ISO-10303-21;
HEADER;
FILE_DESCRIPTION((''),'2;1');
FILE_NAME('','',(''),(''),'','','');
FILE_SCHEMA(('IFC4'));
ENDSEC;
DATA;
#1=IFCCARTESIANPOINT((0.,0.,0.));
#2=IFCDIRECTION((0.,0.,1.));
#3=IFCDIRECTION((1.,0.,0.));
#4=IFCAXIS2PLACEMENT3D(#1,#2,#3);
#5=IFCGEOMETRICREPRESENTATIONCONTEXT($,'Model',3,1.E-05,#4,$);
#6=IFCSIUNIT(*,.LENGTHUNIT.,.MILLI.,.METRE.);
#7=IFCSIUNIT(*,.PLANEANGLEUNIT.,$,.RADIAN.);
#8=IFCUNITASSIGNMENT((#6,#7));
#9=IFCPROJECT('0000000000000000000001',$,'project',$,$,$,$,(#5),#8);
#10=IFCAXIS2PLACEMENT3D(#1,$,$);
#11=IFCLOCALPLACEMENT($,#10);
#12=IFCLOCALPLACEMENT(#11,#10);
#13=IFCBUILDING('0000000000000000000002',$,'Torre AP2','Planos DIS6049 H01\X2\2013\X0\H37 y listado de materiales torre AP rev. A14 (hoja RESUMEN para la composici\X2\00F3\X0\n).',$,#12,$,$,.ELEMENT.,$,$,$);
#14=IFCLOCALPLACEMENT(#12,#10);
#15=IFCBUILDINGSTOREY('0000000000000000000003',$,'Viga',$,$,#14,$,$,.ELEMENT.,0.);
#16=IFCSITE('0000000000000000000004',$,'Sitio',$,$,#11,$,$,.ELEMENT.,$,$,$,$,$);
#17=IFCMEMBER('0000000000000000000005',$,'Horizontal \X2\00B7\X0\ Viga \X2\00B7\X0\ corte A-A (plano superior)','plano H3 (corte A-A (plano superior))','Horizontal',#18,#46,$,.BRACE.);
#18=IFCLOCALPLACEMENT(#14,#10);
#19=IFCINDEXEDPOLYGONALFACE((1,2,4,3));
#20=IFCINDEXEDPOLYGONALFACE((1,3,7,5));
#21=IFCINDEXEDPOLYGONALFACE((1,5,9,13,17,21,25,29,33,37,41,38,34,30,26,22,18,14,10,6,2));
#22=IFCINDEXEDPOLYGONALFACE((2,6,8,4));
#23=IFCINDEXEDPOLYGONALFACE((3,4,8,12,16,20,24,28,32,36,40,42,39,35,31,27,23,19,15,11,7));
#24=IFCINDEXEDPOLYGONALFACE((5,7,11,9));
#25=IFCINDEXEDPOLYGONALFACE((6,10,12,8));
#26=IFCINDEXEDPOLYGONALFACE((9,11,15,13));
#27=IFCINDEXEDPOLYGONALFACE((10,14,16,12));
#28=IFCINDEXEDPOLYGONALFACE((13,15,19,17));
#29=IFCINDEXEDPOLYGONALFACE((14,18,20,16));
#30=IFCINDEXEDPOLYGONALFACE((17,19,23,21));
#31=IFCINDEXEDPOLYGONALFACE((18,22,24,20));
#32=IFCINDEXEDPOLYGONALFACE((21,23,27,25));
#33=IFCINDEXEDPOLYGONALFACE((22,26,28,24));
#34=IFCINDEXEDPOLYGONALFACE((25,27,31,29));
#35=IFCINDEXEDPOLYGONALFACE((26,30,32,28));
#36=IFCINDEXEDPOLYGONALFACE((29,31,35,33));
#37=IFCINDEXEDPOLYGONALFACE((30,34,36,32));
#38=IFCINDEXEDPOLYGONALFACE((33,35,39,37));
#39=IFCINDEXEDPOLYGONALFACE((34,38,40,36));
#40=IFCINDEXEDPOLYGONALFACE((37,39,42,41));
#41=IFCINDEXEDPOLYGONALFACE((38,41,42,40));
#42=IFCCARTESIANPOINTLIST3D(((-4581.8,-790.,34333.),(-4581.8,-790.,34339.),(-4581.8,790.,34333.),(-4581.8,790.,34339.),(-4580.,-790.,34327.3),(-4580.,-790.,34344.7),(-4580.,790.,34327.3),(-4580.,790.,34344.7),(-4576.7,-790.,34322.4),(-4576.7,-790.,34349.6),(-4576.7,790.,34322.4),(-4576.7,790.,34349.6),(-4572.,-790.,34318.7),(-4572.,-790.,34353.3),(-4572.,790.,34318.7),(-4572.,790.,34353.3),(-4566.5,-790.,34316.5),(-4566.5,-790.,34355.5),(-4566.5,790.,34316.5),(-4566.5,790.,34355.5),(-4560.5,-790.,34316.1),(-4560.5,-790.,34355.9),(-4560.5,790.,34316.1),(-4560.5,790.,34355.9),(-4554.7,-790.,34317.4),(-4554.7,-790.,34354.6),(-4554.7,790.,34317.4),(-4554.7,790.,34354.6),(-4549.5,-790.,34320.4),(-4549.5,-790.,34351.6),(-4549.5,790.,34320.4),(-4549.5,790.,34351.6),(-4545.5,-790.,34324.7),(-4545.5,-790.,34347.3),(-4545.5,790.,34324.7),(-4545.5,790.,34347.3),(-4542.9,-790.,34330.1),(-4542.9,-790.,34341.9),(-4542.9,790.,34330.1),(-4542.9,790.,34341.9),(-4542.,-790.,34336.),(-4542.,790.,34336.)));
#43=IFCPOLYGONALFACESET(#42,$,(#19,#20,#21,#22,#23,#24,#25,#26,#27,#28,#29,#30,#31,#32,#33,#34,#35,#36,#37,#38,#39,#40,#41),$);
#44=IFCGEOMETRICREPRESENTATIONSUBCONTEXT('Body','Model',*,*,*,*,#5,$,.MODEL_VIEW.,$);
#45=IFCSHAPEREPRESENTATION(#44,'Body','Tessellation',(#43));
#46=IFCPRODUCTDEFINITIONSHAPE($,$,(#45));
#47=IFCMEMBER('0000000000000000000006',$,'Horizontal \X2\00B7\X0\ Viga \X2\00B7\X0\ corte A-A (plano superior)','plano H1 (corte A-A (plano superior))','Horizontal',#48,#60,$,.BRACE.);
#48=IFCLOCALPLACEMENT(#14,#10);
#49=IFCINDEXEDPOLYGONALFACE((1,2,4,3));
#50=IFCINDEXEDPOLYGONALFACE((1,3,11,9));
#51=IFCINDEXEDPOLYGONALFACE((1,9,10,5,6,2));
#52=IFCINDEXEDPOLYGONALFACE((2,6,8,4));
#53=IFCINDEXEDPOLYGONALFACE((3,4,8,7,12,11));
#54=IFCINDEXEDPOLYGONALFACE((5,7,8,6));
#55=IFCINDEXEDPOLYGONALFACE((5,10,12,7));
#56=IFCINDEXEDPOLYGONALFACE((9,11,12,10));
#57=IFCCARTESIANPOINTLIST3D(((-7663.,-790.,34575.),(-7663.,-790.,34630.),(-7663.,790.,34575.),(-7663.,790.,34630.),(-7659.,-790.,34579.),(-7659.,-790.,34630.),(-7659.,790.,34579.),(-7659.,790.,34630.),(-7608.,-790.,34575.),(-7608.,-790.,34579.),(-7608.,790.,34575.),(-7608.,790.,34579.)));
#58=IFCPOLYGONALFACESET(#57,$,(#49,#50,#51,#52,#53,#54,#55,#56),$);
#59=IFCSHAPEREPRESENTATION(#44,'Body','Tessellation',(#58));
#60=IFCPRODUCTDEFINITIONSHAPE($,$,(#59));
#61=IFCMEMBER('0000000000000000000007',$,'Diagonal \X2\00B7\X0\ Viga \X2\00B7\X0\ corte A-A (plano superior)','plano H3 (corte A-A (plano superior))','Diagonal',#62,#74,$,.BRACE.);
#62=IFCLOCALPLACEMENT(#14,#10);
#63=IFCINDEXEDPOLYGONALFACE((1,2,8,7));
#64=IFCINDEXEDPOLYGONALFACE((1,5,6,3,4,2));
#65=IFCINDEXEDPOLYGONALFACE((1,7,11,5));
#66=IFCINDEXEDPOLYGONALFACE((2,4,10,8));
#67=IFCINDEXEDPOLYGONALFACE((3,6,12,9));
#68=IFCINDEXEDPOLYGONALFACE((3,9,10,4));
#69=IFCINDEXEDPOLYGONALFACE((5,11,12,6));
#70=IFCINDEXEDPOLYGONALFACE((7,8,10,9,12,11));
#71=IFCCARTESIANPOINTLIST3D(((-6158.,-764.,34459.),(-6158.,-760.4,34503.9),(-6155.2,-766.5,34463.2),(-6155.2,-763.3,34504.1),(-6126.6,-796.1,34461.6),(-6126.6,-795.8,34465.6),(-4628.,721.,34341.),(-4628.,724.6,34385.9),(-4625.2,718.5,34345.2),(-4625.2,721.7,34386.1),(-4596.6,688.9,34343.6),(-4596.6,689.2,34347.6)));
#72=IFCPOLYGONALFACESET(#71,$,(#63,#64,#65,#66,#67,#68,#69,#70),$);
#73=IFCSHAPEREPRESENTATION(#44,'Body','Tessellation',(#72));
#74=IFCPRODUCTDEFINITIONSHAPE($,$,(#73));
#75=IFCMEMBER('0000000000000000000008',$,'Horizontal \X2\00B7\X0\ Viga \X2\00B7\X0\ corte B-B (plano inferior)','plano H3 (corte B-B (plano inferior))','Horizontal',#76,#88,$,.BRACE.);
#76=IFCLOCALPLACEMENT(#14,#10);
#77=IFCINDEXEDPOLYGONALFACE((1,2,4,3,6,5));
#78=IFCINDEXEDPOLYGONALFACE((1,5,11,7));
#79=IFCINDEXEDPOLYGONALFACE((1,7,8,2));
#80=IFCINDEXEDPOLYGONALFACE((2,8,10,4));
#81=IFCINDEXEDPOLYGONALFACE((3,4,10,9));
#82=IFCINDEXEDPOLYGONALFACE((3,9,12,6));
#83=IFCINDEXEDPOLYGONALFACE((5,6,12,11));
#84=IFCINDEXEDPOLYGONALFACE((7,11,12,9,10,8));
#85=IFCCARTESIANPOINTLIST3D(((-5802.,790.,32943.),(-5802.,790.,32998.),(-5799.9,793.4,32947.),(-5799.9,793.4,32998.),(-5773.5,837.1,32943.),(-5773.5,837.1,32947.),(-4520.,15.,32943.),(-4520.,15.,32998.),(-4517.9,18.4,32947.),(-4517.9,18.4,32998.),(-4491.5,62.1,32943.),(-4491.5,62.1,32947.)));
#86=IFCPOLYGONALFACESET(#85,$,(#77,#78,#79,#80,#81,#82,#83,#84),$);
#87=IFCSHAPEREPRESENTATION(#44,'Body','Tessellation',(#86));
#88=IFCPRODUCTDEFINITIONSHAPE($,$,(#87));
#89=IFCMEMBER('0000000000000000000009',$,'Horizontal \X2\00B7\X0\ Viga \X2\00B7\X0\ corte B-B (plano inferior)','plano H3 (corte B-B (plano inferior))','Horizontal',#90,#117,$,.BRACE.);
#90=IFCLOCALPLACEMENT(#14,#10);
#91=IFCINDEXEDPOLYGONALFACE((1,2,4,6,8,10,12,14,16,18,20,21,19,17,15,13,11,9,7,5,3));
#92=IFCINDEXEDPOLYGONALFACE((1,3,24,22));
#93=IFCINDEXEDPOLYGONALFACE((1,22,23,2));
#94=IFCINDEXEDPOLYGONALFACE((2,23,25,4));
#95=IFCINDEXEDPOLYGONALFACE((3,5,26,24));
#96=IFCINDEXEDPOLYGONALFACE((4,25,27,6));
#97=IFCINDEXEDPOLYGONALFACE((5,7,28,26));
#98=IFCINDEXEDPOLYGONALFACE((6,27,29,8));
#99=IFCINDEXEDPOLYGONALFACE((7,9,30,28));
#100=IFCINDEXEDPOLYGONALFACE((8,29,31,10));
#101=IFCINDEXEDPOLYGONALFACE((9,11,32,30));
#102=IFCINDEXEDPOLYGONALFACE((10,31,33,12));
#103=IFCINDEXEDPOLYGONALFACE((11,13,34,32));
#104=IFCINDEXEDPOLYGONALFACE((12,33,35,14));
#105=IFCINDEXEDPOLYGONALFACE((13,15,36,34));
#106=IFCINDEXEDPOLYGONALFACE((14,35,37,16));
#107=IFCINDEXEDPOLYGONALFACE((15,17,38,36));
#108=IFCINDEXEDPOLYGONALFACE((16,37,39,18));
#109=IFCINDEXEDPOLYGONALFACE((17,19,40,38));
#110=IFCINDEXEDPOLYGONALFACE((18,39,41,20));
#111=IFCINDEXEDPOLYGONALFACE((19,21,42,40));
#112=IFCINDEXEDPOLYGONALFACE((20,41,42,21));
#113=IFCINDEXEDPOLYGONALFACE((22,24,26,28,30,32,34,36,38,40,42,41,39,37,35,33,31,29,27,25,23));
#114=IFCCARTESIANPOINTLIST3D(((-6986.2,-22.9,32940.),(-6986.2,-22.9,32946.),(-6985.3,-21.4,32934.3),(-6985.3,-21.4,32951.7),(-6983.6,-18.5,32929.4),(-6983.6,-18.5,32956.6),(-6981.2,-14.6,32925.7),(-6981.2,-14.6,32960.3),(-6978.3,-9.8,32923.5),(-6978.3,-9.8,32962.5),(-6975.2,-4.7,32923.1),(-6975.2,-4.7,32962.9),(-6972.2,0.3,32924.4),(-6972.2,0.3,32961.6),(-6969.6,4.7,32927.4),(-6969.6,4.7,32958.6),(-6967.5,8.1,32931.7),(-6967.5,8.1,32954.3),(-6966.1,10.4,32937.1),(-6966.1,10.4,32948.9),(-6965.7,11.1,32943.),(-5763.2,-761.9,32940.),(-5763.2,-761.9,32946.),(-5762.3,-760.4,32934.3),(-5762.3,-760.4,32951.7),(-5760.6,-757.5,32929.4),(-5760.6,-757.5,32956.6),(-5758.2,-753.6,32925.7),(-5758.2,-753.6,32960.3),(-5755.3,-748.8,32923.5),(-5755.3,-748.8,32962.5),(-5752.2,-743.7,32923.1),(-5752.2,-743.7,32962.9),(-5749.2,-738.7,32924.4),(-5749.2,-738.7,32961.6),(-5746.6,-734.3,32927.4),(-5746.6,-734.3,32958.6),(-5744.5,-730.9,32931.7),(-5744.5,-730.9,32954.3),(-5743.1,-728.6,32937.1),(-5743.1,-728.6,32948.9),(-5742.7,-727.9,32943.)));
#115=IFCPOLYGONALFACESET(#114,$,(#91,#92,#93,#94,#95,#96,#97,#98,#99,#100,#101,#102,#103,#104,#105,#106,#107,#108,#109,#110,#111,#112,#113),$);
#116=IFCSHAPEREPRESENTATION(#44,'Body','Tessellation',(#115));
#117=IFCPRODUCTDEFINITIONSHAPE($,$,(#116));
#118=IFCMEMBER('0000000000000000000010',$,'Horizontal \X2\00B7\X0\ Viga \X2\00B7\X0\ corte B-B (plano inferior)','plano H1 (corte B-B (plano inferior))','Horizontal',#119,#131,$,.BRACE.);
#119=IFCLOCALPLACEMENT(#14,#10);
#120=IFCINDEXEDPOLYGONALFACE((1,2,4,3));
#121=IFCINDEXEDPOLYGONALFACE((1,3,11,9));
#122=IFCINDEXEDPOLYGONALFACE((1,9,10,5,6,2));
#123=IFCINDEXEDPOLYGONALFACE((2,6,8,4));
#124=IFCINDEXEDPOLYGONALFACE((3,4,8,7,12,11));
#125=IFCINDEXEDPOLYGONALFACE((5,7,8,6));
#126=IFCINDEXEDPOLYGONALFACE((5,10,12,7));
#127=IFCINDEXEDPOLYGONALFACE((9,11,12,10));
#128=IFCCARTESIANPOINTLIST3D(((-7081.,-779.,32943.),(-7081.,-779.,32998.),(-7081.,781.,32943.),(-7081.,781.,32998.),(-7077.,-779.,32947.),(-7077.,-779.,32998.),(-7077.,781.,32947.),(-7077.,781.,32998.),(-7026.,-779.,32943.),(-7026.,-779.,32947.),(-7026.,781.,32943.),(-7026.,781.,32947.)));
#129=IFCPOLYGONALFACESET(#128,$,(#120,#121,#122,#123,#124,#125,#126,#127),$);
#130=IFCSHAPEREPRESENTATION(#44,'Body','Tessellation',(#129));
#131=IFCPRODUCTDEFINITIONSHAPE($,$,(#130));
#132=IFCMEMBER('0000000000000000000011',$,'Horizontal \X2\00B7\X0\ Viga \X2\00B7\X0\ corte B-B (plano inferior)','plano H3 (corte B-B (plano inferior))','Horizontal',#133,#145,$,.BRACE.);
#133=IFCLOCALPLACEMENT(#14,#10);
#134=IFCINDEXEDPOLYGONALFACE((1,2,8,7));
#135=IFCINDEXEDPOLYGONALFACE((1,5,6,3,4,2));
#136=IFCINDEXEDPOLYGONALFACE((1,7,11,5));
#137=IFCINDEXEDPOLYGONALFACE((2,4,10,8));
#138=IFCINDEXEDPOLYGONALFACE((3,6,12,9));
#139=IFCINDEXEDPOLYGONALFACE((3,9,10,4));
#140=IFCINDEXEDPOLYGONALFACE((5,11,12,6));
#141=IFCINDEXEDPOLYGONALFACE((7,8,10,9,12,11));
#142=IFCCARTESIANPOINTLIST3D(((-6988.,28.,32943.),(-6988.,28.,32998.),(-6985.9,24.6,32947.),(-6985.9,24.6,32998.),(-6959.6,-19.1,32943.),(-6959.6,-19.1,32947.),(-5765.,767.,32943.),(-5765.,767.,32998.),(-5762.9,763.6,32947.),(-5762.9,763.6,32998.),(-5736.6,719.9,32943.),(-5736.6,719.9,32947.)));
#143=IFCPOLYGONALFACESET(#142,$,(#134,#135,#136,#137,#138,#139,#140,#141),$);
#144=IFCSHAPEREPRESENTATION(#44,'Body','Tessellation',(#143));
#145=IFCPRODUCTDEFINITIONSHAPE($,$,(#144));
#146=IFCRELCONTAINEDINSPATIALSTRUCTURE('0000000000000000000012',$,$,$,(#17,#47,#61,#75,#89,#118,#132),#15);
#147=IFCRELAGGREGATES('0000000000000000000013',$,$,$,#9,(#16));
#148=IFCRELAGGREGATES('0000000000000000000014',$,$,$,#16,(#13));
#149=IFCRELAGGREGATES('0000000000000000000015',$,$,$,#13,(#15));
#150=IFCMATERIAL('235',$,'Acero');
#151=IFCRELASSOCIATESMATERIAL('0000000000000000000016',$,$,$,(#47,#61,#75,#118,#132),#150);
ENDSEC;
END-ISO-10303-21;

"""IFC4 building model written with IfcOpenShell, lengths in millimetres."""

from ifc_helpers import new_model, si_unit, frame, frame_2d, origin, origin_with_axes, place, context, subcontext, project, spatial, circle, l_section, extrude, material, element, save


model = new_model("IFC4")

# Units and contexts
model_context = context("Model", 3, precision=1e-05, world=origin_with_axes())
body_context = subcontext(model_context, "Body", "Model", "MODEL_VIEW")
ifc_project = project(units=[si_unit("LENGTHUNIT", "METRE", prefix="MILLI"), si_unit("PLANEANGLEUNIT", "RADIAN")], contexts=[model_context])

# Site, building, storey
site_placement = place(None, origin())
site = spatial("IfcSite", under=ifc_project, at=site_placement, Name="Sitio", CompositionType="ELEMENT")
building_placement = place(site_placement, origin())
building = spatial("IfcBuilding", under=site, at=building_placement, Name="Torre AP2", Description="Planos DIS6049 H01–H37 y listado de materiales torre AP rev. A14 (hoja RESUMEN para la composición).", CompositionType="ELEMENT")
storey_placement = place(building_placement, origin())
storey = spatial("IfcBuildingStorey", under=building, at=storey_placement, Name="Viga", CompositionType="ELEMENT", Elevation=0.0)

# Members
ifc_material_1 = material(Name="235", Category="Acero")
member_1_placement = place(storey_placement, frame((-4562.0, 790.0, 34336.0), z_axis=(0.0, -1.0, 0.0), x_axis=(1.0, 0.0, 0.0)))
element("IfcMember", 1, at=member_1_placement, inside=storey, Name="Horizontal · Viga · corte A-A (plano superior)", Description="plano H3 (corte A-A (plano superior))", ObjectType="Horizontal", PredefinedType="BRACE", context=body_context, shape_type="SweptSolid", body=[
    extrude(circle(Radius=20.0), None, (0.0, 0.0, 1.0), 1580.0),
])
member_2_placement = place(storey_placement, frame((-7663.0, 790.0, 34575.0), z_axis=(0.0, -1.0, 0.0), x_axis=(1.0, 0.0, 0.0)))
element("IfcMember", 2, at=member_2_placement, inside=storey, material=ifc_material_1, Name="Horizontal · Viga · corte A-A (plano superior)", Description="plano H1 (corte A-A (plano superior))", ObjectType="Horizontal", PredefinedType="BRACE", context=body_context, shape_type="SweptSolid", body=[
    extrude(l_section(Depth=55.0, Width=55.0, Thickness=4.0, at=frame_2d((27.5, 27.5))), None, (0.0, 0.0, 1.0), 1580.0),
])
member_3_placement = place(storey_placement, frame((-4628.0, 721.0, 34341.0), z_axis=(-0.716484, -0.695411, 0.055258), x_axis=(0.697603, -0.714197, 0.057207)))
element("IfcMember", 3, at=member_3_placement, inside=storey, material=ifc_material_1, Name="Diagonal · Viga · corte A-A (plano superior)", Description="plano H3 (corte A-A (plano superior))", ObjectType="Diagonal", PredefinedType="BRACE", context=body_context, shape_type="SweptSolid", body=[
    extrude(l_section(Depth=45.0, Width=45.0, Thickness=4.0, at=frame_2d((22.5, 22.5))), None, (0.0, 0.0, 1.0), 2135.4),
])
member_4_placement = place(storey_placement, frame((-5802.0, 790.0, 32943.0), z_axis=(0.85578, -0.51734, 0.0), x_axis=(0.51734, 0.85578, 0.0)))
element("IfcMember", 4, at=member_4_placement, inside=storey, material=ifc_material_1, Name="Horizontal · Viga · corte B-B (plano inferior)", Description="plano H3 (corte B-B (plano inferior))", ObjectType="Horizontal", PredefinedType="BRACE", context=body_context, shape_type="SweptSolid", body=[
    extrude(l_section(Depth=55.0, Width=55.0, Thickness=4.0, at=frame_2d((27.5, 27.5))), None, (0.0, 0.0, 1.0), 1498.0),
])
member_5_placement = place(storey_placement, frame((-6976.0, -6.0, 32943.0), z_axis=(0.855883, -0.517169, 0.0), x_axis=(0.517169, 0.855883, 0.0)))
element("IfcMember", 5, at=member_5_placement, inside=storey, Name="Horizontal · Viga · corte B-B (plano inferior)", Description="plano H3 (corte B-B (plano inferior))", ObjectType="Horizontal", PredefinedType="BRACE", context=body_context, shape_type="SweptSolid", body=[
    extrude(circle(Radius=20.0), None, (0.0, 0.0, 1.0), 1428.9),
])
member_6_placement = place(storey_placement, frame((-7081.0, 781.0, 32943.0), z_axis=(0.0, -1.0, 0.0), x_axis=(1.0, 0.0, 0.0)))
element("IfcMember", 6, at=member_6_placement, inside=storey, material=ifc_material_1, Name="Horizontal · Viga · corte B-B (plano inferior)", Description="plano H1 (corte B-B (plano inferior))", ObjectType="Horizontal", PredefinedType="BRACE", context=body_context, shape_type="SweptSolid", body=[
    extrude(l_section(Depth=55.0, Width=55.0, Thickness=4.0, at=frame_2d((27.5, 27.5))), None, (0.0, 0.0, 1.0), 1560.0),
])
member_7_placement = place(storey_placement, frame((-5765.0, 767.0, 32943.0), z_axis=(-0.855883, -0.517169, 0.0), x_axis=(0.517169, -0.855883, 0.0)))
element("IfcMember", 7, at=member_7_placement, inside=storey, material=ifc_material_1, Name="Horizontal · Viga · corte B-B (plano inferior)", Description="plano H3 (corte B-B (plano inferior))", ObjectType="Horizontal", PredefinedType="BRACE", context=body_context, shape_type="SweptSolid", body=[
    extrude(l_section(Depth=55.0, Width=55.0, Thickness=4.0, at=frame_2d((27.5, 27.5))), None, (0.0, 0.0, 1.0), 1428.9),
])

save(model, "model.ifc")
